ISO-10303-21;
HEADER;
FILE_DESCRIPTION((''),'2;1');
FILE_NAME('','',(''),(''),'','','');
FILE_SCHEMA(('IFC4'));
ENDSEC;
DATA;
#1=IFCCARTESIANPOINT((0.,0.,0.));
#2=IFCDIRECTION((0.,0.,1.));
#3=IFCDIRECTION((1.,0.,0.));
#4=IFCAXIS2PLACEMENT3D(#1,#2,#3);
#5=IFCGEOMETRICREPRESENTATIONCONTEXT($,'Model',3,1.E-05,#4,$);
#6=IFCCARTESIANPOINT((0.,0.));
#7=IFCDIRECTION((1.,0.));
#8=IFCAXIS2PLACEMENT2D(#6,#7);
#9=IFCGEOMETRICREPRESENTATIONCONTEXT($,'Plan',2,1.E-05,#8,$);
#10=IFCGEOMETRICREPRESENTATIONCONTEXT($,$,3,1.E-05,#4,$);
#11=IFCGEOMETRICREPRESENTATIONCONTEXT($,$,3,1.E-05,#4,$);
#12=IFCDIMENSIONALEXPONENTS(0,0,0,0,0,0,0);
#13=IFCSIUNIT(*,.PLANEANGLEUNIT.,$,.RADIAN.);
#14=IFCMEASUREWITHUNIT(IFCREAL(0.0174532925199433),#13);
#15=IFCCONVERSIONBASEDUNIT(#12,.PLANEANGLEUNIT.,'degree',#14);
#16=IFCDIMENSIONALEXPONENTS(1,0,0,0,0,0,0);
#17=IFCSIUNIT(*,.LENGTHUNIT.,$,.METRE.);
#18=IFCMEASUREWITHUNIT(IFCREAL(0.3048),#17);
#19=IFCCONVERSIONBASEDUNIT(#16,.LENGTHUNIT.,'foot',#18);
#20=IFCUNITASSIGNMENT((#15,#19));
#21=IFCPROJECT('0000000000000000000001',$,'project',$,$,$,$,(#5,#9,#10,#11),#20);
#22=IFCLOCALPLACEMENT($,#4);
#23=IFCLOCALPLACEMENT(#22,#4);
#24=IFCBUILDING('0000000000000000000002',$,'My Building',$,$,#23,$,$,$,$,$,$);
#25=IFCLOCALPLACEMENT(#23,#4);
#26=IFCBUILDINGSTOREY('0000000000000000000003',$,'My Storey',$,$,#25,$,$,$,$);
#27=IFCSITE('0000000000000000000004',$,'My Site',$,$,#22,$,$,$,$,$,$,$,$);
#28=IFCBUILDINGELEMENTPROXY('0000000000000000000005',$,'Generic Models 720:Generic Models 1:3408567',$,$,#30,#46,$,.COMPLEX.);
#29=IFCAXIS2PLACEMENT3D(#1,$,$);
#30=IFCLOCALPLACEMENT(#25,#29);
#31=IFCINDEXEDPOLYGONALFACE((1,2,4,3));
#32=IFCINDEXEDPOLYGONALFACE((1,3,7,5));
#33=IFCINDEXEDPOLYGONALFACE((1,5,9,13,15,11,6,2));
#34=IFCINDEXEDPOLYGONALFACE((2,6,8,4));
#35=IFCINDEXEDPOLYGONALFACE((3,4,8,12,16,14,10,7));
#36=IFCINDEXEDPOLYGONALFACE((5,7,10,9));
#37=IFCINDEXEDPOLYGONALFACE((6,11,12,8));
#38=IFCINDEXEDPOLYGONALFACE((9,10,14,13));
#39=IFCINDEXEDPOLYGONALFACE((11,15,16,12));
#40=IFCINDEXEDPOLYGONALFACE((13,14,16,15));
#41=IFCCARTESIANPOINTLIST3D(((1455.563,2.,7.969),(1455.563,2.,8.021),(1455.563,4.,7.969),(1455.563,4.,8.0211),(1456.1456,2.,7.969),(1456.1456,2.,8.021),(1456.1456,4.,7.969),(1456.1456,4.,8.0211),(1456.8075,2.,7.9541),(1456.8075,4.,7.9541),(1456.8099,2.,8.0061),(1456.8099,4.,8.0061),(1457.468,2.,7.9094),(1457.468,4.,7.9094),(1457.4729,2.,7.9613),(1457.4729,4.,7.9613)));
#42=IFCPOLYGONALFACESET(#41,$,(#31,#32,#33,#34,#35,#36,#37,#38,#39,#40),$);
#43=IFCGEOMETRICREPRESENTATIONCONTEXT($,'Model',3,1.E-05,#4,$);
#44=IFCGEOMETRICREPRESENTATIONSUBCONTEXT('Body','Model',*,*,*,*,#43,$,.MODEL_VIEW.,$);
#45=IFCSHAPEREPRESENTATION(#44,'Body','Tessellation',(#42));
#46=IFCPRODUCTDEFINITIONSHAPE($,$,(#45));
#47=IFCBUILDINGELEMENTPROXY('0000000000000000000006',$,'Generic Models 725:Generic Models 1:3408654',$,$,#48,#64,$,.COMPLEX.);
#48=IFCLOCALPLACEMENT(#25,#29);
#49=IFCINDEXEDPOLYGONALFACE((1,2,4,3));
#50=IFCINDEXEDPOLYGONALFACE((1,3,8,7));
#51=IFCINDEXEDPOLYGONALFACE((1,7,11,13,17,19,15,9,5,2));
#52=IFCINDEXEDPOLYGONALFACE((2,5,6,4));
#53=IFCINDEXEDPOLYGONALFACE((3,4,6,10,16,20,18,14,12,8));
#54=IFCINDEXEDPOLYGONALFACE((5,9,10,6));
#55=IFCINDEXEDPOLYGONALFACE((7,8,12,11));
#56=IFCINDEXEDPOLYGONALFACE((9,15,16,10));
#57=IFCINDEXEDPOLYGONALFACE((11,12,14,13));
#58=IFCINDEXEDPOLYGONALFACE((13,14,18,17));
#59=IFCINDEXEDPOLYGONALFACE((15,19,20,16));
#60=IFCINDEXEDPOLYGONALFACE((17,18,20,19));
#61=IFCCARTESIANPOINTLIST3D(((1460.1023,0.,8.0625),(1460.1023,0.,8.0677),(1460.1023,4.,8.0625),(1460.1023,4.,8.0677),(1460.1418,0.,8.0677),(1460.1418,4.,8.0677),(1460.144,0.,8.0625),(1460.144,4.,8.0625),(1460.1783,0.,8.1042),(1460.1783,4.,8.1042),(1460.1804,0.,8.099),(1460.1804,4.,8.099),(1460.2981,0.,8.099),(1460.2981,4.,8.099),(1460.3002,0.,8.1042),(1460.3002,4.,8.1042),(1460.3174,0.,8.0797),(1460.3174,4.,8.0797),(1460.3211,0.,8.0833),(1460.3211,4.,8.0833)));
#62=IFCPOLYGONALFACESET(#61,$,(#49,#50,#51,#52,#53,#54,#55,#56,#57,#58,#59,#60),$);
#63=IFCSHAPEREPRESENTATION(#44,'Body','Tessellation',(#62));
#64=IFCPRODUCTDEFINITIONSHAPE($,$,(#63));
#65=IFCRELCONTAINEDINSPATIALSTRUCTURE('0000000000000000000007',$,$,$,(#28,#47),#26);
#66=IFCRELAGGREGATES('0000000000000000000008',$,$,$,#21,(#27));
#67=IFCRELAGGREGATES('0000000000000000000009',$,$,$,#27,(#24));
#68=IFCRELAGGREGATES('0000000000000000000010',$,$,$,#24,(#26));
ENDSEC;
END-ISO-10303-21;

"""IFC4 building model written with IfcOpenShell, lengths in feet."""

from ifc_helpers import new_model, entity, si_unit, converted_unit, frame, origin_with_axes, origin_2d_with_axis, place, context, subcontext, project, spatial, polyline, outline, extrude, element, save


model = new_model("IFC4")

# Units and contexts
model_context_1 = context("Model", 3, precision=1e-05, world=origin_with_axes())
plan_context = context("Plan", 2, precision=1e-05, world=origin_2d_with_axis())
model_context_2 = context("Model", 3, precision=1e-05, world=origin_with_axes())
context_of_model_1 = context(None, 3, precision=1e-05, world=origin_with_axes())
context_of_model_2 = context(None, 3, precision=1e-05, world=origin_with_axes())
body_context = subcontext(model_context_2, "Body", "Model", "MODEL_VIEW")
ifc_project = project(units=[converted_unit("PLANEANGLEUNIT", "degree", entity("IfcReal", 0.0174532925199433), si_unit("PLANEANGLEUNIT", "RADIAN"), dimensions=[0, 0, 0, 0, 0, 0, 0]), converted_unit("LENGTHUNIT", "foot", entity("IfcReal", 0.3048), si_unit("LENGTHUNIT", "METRE"), dimensions=[1, 0, 0, 0, 0, 0, 0])], contexts=[model_context_1, plan_context, context_of_model_1, context_of_model_2])

# Site, building, storey
site_placement = place(None, origin_with_axes())
site = spatial("IfcSite", under=ifc_project, at=site_placement, Name="My Site")
building_placement = place(site_placement, origin_with_axes())
building = spatial("IfcBuilding", under=site, at=building_placement, Name="My Building")
storey_placement = place(building_placement, origin_with_axes())
storey = spatial("IfcBuildingStorey", under=building, at=storey_placement, Name="My Storey")

# Building element proxies
proxy_1_placement = place(storey_placement, frame((1455.563, 6.0, 7.9094), z_axis=(0.0, -1.0, 0.0), x_axis=(0.0, 0.0, 1.0)))
element("IfcBuildingElementProxy", 1, at=proxy_1_placement, inside=storey, Name="Generic Models 720:Generic Models 1:3408567", PredefinedType="COMPLEX", context=body_context, shape_type="SweptSolid", body=[
    extrude(outline(polyline([(-0.0074, -0.9339), (0.0447, -0.9339), (0.0447, -0.3513), (0.0297, 0.313), (-0.0151, 0.9759), (-0.0669, 0.9711), (-0.0223, 0.3105), (-0.0074, -0.3513), (-0.0074, -0.9339)])), frame((0.0669, -0.9339, 2.0), z_axis=(0.000003, 0.0, -1.0), x_axis=(1.0, 0.0, 0.0)), (0.0, 0.0, -1.0), 2.0),
])
proxy_2_placement = place(storey_placement, frame((1460.1023, 4.0, 8.0625), z_axis=(0.0, -1.0, 0.0), x_axis=(0.0, 0.0, 1.0)))
element("IfcBuildingElementProxy", 2, at=proxy_2_placement, inside=storey, Name="Generic Models 725:Generic Models 1:3408654", PredefinedType="COMPLEX", context=body_context, shape_type="SweptSolid", body=[
    extrude(outline(polyline([(0.1082, 0.0), (0.1072, 0.0051), (0.0684, -0.0024), (0.0258, 0.0266), (-0.094, 0.0035), (-0.1105, -0.0209), (-0.1062, -0.0238), (-0.0909, -0.0012), (0.0246, 0.021), (0.0673, -0.0079), (0.1082, 0.0)])), frame((0.0205, -0.1063, 0.0), z_axis=(0.0, 0.0, -1.0), x_axis=(-0.189091, 0.98196, 0.0)), (0.0, 0.0, -1.0), 4.0),
])

save(model, "model.ifc")
